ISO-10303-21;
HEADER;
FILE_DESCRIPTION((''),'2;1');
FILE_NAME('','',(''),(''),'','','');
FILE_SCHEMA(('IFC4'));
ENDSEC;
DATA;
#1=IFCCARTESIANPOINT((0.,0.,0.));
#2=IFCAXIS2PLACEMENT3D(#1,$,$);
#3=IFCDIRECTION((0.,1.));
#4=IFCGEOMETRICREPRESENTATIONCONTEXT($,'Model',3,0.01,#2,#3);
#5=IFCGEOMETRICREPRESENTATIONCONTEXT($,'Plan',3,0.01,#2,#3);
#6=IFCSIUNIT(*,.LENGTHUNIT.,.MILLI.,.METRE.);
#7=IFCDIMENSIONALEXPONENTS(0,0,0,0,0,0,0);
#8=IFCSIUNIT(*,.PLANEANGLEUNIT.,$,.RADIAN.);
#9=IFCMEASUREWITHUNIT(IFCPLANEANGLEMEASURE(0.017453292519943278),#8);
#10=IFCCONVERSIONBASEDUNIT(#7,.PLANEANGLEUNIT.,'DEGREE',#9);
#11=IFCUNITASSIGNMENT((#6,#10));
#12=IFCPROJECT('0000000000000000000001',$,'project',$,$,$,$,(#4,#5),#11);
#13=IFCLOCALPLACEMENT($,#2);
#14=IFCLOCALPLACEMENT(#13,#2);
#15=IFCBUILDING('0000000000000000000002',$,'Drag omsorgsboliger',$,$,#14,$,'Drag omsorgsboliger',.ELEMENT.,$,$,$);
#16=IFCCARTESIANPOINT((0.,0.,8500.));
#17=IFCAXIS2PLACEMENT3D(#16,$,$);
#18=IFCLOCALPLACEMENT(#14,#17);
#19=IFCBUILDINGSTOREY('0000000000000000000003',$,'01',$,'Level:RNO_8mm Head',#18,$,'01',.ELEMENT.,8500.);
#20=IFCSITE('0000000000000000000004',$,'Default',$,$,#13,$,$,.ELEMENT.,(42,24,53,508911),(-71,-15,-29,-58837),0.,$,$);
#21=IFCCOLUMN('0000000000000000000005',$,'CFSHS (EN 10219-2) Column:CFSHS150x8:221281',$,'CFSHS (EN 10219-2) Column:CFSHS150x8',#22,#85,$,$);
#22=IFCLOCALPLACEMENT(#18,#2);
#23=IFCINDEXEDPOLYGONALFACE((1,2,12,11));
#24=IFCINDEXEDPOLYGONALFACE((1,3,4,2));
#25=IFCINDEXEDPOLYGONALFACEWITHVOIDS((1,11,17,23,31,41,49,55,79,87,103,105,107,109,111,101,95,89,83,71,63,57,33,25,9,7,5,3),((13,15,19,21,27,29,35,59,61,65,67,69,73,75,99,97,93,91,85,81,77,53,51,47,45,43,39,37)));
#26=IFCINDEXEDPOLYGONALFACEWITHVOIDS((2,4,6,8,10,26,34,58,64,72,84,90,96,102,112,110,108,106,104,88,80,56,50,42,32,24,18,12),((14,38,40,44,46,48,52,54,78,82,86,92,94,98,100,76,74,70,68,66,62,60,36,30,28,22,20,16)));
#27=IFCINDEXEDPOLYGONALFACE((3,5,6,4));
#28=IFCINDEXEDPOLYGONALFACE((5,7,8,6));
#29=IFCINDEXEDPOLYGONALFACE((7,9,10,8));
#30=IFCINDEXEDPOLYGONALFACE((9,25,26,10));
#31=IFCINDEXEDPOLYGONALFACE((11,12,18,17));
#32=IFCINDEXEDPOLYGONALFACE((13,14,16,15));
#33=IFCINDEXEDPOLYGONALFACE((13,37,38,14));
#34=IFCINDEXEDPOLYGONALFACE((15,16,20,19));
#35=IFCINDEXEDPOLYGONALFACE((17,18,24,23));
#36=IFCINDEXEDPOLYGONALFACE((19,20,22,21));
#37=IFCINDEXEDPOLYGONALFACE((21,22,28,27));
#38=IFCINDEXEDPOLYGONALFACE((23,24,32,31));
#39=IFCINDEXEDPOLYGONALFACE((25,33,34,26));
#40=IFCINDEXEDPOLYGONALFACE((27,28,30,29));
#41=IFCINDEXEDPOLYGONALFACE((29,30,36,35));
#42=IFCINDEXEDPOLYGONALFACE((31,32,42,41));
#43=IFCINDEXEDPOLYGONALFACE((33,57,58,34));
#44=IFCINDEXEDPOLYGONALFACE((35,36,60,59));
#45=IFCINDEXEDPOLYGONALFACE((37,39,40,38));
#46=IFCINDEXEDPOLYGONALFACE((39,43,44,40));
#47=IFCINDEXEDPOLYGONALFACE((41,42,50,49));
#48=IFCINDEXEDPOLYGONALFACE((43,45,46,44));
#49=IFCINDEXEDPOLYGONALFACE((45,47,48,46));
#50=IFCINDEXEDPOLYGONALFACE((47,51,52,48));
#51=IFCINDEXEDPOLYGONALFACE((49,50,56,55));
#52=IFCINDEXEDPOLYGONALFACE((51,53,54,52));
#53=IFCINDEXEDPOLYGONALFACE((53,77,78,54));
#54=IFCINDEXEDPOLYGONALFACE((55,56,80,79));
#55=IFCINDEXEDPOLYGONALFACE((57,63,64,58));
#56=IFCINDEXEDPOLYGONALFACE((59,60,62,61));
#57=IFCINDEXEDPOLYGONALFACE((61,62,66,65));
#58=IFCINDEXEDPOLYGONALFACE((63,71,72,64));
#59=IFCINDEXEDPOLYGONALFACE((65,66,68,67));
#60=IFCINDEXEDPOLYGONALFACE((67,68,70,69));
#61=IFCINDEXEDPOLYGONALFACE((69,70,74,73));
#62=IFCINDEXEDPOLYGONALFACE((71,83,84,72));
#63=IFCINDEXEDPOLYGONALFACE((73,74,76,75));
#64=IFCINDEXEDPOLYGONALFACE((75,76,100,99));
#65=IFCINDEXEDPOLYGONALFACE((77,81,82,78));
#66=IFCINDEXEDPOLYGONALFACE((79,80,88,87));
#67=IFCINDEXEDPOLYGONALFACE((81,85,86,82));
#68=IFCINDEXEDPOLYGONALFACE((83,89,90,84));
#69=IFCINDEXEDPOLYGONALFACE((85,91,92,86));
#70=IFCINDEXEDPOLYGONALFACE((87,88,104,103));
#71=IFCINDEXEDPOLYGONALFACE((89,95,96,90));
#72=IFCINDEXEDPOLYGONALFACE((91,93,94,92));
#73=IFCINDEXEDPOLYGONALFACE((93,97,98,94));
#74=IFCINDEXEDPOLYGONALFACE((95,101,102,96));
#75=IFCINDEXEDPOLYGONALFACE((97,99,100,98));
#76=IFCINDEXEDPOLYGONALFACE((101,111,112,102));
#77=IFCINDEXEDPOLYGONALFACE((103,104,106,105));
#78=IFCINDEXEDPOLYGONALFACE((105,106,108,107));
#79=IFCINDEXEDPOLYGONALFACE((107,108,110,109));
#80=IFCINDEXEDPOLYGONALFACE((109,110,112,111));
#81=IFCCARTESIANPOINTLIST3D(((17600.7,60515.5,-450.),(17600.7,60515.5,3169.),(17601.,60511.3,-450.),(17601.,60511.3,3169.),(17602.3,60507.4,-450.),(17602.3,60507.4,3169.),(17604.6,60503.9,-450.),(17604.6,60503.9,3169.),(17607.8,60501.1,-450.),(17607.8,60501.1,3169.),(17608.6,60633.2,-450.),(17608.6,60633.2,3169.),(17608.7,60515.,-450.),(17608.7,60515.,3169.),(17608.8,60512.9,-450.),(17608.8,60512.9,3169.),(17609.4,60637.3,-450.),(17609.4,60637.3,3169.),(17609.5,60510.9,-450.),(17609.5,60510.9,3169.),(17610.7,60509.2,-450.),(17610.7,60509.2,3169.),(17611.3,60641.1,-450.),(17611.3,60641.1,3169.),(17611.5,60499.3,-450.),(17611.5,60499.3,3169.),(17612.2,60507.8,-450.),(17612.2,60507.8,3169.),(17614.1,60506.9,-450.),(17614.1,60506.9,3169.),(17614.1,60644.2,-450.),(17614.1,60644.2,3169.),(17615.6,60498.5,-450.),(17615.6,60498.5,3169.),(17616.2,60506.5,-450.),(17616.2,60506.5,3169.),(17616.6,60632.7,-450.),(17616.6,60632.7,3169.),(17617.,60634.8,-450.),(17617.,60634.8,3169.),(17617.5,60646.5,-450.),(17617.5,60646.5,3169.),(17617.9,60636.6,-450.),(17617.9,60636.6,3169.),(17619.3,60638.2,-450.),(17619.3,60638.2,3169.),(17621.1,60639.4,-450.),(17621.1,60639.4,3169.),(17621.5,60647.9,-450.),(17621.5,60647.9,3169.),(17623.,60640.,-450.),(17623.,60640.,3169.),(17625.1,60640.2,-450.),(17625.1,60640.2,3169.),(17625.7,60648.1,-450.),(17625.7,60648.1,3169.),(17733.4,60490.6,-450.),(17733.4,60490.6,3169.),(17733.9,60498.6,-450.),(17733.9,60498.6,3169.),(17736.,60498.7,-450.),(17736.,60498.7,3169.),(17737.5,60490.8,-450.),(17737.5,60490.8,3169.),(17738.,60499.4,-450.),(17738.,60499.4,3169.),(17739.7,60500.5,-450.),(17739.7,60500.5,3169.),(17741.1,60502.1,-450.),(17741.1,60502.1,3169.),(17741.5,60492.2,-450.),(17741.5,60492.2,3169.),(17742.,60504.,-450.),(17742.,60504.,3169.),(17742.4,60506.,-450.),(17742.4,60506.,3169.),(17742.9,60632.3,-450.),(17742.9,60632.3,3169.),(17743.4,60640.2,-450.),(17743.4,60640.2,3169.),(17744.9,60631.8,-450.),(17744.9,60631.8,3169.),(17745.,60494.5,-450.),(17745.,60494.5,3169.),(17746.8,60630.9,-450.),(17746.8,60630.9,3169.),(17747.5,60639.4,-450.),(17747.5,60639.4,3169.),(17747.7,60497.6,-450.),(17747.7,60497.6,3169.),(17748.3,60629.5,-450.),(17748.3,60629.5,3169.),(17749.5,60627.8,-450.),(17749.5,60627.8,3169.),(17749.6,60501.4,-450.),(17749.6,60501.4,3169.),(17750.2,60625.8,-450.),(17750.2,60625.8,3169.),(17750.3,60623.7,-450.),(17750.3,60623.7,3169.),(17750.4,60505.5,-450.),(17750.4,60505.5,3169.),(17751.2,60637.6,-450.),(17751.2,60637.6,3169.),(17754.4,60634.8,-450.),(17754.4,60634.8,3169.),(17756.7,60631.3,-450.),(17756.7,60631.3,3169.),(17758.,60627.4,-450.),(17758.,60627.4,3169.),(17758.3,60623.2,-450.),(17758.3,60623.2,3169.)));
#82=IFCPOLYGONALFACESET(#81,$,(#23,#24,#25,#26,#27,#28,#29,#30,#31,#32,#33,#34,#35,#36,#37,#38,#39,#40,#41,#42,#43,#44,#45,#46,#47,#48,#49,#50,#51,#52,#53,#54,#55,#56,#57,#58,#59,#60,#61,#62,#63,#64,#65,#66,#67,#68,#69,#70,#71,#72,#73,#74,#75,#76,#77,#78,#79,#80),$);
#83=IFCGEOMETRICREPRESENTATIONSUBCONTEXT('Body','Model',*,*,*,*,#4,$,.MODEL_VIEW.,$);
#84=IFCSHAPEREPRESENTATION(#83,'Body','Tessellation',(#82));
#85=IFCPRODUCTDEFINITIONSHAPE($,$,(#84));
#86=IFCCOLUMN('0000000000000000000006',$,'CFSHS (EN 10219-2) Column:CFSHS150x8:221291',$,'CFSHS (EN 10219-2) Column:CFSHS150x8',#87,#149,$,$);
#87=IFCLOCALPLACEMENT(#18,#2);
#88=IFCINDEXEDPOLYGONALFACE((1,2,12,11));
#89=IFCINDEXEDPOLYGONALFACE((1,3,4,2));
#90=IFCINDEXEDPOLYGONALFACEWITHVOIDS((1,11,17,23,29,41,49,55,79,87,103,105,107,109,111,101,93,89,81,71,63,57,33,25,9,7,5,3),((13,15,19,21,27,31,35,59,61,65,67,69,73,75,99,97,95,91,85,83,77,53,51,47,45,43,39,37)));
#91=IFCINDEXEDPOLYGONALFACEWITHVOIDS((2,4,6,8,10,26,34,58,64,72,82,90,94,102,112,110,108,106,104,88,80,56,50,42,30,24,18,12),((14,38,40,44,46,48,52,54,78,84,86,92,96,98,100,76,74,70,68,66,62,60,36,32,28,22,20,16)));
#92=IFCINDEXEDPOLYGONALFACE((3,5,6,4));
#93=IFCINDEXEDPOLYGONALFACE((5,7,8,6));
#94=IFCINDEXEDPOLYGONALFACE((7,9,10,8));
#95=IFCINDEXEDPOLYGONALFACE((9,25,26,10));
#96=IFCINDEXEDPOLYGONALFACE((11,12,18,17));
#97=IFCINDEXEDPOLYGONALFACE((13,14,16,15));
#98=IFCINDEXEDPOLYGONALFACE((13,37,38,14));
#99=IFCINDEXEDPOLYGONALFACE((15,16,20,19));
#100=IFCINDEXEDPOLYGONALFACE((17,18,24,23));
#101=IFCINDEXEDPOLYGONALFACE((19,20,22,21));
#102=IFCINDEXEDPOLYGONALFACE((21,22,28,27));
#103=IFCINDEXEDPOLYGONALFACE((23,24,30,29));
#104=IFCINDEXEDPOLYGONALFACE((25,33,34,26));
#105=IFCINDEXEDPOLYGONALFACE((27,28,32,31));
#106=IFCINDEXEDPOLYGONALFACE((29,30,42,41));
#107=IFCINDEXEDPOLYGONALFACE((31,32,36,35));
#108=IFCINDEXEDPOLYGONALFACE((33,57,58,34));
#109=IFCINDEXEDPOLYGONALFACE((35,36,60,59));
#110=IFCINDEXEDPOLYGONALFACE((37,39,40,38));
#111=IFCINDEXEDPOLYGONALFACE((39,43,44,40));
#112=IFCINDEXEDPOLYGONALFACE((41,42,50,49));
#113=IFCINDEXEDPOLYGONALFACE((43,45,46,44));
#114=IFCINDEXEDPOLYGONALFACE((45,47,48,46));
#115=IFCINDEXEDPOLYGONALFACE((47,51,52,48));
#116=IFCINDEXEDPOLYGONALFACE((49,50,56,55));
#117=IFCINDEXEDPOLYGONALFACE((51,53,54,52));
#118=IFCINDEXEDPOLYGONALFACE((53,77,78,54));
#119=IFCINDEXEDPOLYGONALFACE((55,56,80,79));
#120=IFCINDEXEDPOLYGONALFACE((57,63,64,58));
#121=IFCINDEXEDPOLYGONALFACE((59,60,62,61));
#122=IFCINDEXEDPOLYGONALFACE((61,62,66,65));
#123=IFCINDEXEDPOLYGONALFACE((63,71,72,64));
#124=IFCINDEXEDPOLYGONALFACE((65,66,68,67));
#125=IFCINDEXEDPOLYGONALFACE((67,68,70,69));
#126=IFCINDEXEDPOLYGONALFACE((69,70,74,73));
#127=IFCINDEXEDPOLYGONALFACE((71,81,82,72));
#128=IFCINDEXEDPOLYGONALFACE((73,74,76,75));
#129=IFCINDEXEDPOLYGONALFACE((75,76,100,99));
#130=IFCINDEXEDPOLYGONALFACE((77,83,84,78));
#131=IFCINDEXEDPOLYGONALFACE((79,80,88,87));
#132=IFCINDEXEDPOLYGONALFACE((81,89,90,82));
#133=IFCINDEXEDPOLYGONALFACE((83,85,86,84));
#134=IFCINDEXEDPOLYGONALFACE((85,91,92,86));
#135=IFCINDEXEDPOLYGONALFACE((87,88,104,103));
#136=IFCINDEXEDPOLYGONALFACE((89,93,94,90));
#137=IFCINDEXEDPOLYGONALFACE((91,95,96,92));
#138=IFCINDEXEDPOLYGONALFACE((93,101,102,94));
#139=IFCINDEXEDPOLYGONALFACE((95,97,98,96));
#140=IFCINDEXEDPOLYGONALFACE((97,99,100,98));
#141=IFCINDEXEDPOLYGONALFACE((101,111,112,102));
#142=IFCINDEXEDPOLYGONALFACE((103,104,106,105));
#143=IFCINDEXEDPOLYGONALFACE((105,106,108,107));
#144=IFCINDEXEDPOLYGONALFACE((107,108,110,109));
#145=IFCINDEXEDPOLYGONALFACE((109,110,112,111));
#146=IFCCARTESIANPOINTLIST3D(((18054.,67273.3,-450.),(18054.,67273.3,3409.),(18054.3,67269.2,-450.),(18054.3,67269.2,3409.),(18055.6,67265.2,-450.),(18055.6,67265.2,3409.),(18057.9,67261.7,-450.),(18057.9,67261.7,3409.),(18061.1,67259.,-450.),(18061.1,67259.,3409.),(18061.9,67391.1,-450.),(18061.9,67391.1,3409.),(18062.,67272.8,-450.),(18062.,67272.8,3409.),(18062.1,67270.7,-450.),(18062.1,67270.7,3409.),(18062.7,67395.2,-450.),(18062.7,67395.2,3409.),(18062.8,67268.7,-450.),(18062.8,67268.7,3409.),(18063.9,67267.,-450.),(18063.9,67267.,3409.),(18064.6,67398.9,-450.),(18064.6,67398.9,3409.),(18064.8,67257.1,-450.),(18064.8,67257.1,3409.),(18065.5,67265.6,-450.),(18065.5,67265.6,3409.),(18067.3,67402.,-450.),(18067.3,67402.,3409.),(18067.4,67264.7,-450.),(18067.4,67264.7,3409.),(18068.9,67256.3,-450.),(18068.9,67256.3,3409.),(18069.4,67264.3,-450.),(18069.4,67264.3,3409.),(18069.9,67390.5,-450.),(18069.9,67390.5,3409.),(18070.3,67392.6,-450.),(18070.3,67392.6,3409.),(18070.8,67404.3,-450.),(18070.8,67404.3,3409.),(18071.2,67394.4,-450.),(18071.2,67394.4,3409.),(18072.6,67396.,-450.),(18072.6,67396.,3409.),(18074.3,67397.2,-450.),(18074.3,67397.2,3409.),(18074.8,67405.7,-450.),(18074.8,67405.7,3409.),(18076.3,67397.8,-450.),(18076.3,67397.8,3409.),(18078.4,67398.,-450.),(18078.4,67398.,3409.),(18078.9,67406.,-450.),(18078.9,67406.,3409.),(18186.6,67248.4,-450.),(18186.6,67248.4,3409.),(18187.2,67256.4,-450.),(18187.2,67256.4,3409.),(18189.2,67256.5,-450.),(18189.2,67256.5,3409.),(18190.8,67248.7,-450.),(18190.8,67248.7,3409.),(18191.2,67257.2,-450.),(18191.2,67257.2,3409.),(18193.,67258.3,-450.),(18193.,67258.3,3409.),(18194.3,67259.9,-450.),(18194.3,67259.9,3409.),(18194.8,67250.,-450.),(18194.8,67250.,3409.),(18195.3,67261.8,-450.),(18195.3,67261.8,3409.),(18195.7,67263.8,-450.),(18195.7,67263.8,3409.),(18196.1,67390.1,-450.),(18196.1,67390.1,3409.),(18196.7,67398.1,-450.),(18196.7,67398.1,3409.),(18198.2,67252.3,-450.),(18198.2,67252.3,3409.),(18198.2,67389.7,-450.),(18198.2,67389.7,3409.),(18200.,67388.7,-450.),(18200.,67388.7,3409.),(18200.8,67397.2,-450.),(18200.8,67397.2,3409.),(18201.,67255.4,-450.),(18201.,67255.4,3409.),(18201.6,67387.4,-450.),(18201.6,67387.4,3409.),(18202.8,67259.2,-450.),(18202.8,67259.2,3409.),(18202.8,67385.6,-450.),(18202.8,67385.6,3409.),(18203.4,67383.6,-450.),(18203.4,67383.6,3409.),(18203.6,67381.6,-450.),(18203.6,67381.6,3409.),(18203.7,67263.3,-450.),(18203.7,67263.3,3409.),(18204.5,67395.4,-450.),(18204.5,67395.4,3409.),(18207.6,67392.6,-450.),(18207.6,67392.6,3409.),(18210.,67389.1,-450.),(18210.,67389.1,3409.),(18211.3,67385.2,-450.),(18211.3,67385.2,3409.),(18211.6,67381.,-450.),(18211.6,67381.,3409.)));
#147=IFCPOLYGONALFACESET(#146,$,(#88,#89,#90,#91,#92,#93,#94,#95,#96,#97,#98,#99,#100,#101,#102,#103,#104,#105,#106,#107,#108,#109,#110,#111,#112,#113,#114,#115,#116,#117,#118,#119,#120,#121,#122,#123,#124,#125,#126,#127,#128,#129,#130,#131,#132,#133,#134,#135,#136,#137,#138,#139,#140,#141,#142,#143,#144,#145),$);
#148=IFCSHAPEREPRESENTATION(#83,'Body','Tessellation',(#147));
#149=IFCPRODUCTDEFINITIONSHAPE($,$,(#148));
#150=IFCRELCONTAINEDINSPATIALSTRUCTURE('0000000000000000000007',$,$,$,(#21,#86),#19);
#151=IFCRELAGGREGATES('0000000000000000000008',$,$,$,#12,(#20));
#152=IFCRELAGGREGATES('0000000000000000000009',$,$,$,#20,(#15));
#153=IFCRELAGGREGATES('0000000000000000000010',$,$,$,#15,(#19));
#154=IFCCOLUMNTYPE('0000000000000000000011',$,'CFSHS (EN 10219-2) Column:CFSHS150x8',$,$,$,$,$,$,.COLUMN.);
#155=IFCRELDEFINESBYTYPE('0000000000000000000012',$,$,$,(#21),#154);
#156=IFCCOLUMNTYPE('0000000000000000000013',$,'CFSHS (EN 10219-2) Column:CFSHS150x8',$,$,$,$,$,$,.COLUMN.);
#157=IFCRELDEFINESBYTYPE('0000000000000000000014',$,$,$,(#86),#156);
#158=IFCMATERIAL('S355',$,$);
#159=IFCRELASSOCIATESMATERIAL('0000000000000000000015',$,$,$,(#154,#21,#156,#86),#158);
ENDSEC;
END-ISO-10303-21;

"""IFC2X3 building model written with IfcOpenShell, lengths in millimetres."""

from ifc_helpers import new_model, entity, si_unit, converted_unit, direction, frame, frame_2d, origin, place, context, subcontext, project, spatial, polyline, circle_curve, parameter, trimmed, segment, composite_curve, outline, extrude, source, transform, mapped, material, type_object, type_shapes, element, save


model = new_model("IFC2X3")

# Units and contexts
model_context = context("Model", 3, precision=0.01, world=origin(), true_north=direction((0.0, 1.0)))
plan_context = context("Plan", 3, precision=0.01, world=origin(), true_north=direction((0.0, 1.0)))
body_context = subcontext(model_context, "Body", "Model", "MODEL_VIEW")
ifc_project = project(units=[si_unit("LENGTHUNIT", "METRE", prefix="MILLI"), converted_unit("PLANEANGLEUNIT", "DEGREE", entity("IfcPlaneAngleMeasure", 0.017453292519943278), si_unit("PLANEANGLEUNIT", "RADIAN"), dimensions=[0, 0, 0, 0, 0, 0, 0])], contexts=[model_context, plan_context])

# Site, building, storey
site_placement = place(None, origin())
site = spatial("IfcSite", under=ifc_project, at=site_placement, Name="Default", CompositionType="ELEMENT", RefLatitude=(42, 24, 53, 508911), RefLongitude=(-71, -15, -29, -58837), RefElevation=0.0)
building_placement = place(site_placement, origin())
building = spatial("IfcBuilding", under=site, at=building_placement, Name="Drag omsorgsboliger", LongName="Drag omsorgsboliger", CompositionType="ELEMENT")
storey_placement = place(building_placement, frame((0.0, 0.0, 8500.0)))
storey = spatial("IfcBuildingStorey", under=building, at=storey_placement, Name="01", ObjectType="Level:RNO_8mm Head", LongName="01", CompositionType="ELEMENT", Elevation=8500.0)

# Columns
ifc_material = material(Name="S355")
column_type_1 = type_object("IfcColumnType", Name="CFSHS (EN 10219-2) Column:CFSHS150x8", PredefinedType="COLUMN", material=ifc_material)
shared_shape_1 = source(origin(), body_context, "Body", "SweptSolid", [
    extrude(outline(composite_curve([segment(polyline([(-59.0, -75.0), (59.0, -75.0)]), True, "CONTINUOUS"), segment(trimmed(circle_curve(frame_2d((59.0, -59.0), x_axis=(-1.0, 0.0)), 16.0), [parameter(90.0)], [parameter(180.0)], True, "PARAMETER"), True, "CONTINUOUS"), segment(polyline([(75.0, -59.0), (75.0, 59.0)]), True, "CONTINUOUS"), segment(trimmed(circle_curve(frame_2d((59.0, 59.0), x_axis=(-1.0, 0.0)), 16.0), [parameter(180.0)], [parameter(270.0)], True, "PARAMETER"), True, "CONTINUOUS"), segment(polyline([(59.0, 75.0), (-59.0, 75.0)]), True, "CONTINUOUS"), segment(trimmed(circle_curve(frame_2d((-59.0, 59.0), x_axis=(-1.0, 0.0)), 16.0), [parameter(270.0)], [parameter(360.0)], True, "PARAMETER"), True, "CONTINUOUS"), segment(polyline([(-75.0, 59.0), (-75.0, -59.0)]), True, "CONTINUOUS"), segment(trimmed(circle_curve(frame_2d((-59.0, -59.0), x_axis=(-1.0, 0.0)), 16.0), [parameter(360.0)], [parameter(90.0)], True, "PARAMETER"), True, "CONTINUOUS")], self_intersect=False), holes=[composite_curve([segment(trimmed(circle_curve(frame_2d((-59.0, -59.0), x_axis=(-1.0, 0.0)), 8.0), [parameter(360.0)], [parameter(90.0)], True, "PARAMETER"), False, "CONTINUOUS"), segment(polyline([(-67.0, -59.0), (-67.0, 59.0)]), True, "CONTINUOUS"), segment(trimmed(circle_curve(frame_2d((-59.0, 59.0), x_axis=(-1.0, 0.0)), 8.0), [parameter(270.0)], [parameter(360.0)], True, "PARAMETER"), False, "CONTINUOUS"), segment(polyline([(-59.0, 67.0), (59.0, 67.0)]), True, "CONTINUOUS"), segment(trimmed(circle_curve(frame_2d((59.0, 59.0), x_axis=(-1.0, 0.0)), 8.0), [parameter(180.0)], [parameter(270.0)], True, "PARAMETER"), False, "CONTINUOUS"), segment(polyline([(67.0, 59.0), (67.0, -59.0)]), True, "CONTINUOUS"), segment(trimmed(circle_curve(frame_2d((59.0, -59.0), x_axis=(-1.0, 0.0)), 8.0), [parameter(90.0)], [parameter(180.0)], True, "PARAMETER"), False, "CONTINUOUS"), segment(polyline([(59.0, -67.0), (-59.0, -67.0)]), True, "CONTINUOUS")], self_intersect=False)]), frame((17679.5, 60569.4, 8050.0), z_axis=(0.0, 0.0, 1.0), x_axis=(-0.997758, 0.066923, 0.0)), (0.0, 0.0, 1.0), 3619.0),
])
type_shapes(column_type_1, [shared_shape_1])
column_1_placement = place(storey_placement, frame((0.0, 0.0, -8500.0)))
element("IfcColumn", 1, at=column_1_placement, inside=storey, type_object=column_type_1, material=ifc_material, Name="CFSHS (EN 10219-2) Column:CFSHS150x8:221281", ObjectType="CFSHS (EN 10219-2) Column:CFSHS150x8", context=body_context, shape_type="MappedRepresentation", body=[
    mapped(shared_shape_1, transform((0.0, 0.0, 0.0), scale=1.0)),
])
column_type_2 = type_object("IfcColumnType", Name="CFSHS (EN 10219-2) Column:CFSHS150x8", PredefinedType="COLUMN", material=ifc_material)
shared_shape_2 = source(origin(), body_context, "Body", "SweptSolid", [
    extrude(outline(composite_curve([segment(polyline([(-59.0, -75.0), (59.0, -75.0)]), True, "CONTINUOUS"), segment(trimmed(circle_curve(frame_2d((59.0, -59.0), x_axis=(-1.0, 0.0)), 16.0), [parameter(90.0)], [parameter(180.0)], True, "PARAMETER"), True, "CONTINUOUS"), segment(polyline([(75.0, -59.0), (75.0, 59.0)]), True, "CONTINUOUS"), segment(trimmed(circle_curve(frame_2d((59.0, 59.0), x_axis=(-1.0, 0.0)), 16.0), [parameter(180.0)], [parameter(270.0)], True, "PARAMETER"), True, "CONTINUOUS"), segment(polyline([(59.0, 75.0), (-59.0, 75.0)]), True, "CONTINUOUS"), segment(trimmed(circle_curve(frame_2d((-59.0, 59.0), x_axis=(-1.0, 0.0)), 16.0), [parameter(270.0)], [parameter(360.0)], True, "PARAMETER"), True, "CONTINUOUS"), segment(polyline([(-75.0, 59.0), (-75.0, -59.0)]), True, "CONTINUOUS"), segment(trimmed(circle_curve(frame_2d((-59.0, -59.0), x_axis=(-1.0, 0.0)), 16.0), [parameter(360.0)], [parameter(90.0)], True, "PARAMETER"), True, "CONTINUOUS")], self_intersect=False), holes=[composite_curve([segment(trimmed(circle_curve(frame_2d((-59.0, -59.0), x_axis=(-1.0, 0.0)), 8.0), [parameter(360.0)], [parameter(90.0)], True, "PARAMETER"), False, "CONTINUOUS"), segment(polyline([(-67.0, -59.0), (-67.0, 59.0)]), True, "CONTINUOUS"), segment(trimmed(circle_curve(frame_2d((-59.0, 59.0), x_axis=(-1.0, 0.0)), 8.0), [parameter(270.0)], [parameter(360.0)], True, "PARAMETER"), False, "CONTINUOUS"), segment(polyline([(-59.0, 67.0), (59.0, 67.0)]), True, "CONTINUOUS"), segment(trimmed(circle_curve(frame_2d((59.0, 59.0), x_axis=(-1.0, 0.0)), 8.0), [parameter(180.0)], [parameter(270.0)], True, "PARAMETER"), False, "CONTINUOUS"), segment(polyline([(67.0, 59.0), (67.0, -59.0)]), True, "CONTINUOUS"), segment(trimmed(circle_curve(frame_2d((59.0, -59.0), x_axis=(-1.0, 0.0)), 8.0), [parameter(90.0)], [parameter(180.0)], True, "PARAMETER"), False, "CONTINUOUS"), segment(polyline([(59.0, -67.0), (-59.0, -67.0)]), True, "CONTINUOUS")], self_intersect=False)]), frame((18132.8, 67327.2, 8050.0), z_axis=(0.0, 0.0, 1.0), x_axis=(-0.997758, 0.066923, 0.0)), (0.0, 0.0, 1.0), 3859.0),
])
type_shapes(column_type_2, [shared_shape_2])
column_2_placement = place(storey_placement, frame((0.0, 0.0, -8500.0)))
element("IfcColumn", 2, at=column_2_placement, inside=storey, type_object=column_type_2, material=ifc_material, Name="CFSHS (EN 10219-2) Column:CFSHS150x8:221291", ObjectType="CFSHS (EN 10219-2) Column:CFSHS150x8", context=body_context, shape_type="MappedRepresentation", body=[
    mapped(shared_shape_2, transform((0.0, 0.0, 0.0), scale=1.0)),
])

save(model, "model.ifc")
